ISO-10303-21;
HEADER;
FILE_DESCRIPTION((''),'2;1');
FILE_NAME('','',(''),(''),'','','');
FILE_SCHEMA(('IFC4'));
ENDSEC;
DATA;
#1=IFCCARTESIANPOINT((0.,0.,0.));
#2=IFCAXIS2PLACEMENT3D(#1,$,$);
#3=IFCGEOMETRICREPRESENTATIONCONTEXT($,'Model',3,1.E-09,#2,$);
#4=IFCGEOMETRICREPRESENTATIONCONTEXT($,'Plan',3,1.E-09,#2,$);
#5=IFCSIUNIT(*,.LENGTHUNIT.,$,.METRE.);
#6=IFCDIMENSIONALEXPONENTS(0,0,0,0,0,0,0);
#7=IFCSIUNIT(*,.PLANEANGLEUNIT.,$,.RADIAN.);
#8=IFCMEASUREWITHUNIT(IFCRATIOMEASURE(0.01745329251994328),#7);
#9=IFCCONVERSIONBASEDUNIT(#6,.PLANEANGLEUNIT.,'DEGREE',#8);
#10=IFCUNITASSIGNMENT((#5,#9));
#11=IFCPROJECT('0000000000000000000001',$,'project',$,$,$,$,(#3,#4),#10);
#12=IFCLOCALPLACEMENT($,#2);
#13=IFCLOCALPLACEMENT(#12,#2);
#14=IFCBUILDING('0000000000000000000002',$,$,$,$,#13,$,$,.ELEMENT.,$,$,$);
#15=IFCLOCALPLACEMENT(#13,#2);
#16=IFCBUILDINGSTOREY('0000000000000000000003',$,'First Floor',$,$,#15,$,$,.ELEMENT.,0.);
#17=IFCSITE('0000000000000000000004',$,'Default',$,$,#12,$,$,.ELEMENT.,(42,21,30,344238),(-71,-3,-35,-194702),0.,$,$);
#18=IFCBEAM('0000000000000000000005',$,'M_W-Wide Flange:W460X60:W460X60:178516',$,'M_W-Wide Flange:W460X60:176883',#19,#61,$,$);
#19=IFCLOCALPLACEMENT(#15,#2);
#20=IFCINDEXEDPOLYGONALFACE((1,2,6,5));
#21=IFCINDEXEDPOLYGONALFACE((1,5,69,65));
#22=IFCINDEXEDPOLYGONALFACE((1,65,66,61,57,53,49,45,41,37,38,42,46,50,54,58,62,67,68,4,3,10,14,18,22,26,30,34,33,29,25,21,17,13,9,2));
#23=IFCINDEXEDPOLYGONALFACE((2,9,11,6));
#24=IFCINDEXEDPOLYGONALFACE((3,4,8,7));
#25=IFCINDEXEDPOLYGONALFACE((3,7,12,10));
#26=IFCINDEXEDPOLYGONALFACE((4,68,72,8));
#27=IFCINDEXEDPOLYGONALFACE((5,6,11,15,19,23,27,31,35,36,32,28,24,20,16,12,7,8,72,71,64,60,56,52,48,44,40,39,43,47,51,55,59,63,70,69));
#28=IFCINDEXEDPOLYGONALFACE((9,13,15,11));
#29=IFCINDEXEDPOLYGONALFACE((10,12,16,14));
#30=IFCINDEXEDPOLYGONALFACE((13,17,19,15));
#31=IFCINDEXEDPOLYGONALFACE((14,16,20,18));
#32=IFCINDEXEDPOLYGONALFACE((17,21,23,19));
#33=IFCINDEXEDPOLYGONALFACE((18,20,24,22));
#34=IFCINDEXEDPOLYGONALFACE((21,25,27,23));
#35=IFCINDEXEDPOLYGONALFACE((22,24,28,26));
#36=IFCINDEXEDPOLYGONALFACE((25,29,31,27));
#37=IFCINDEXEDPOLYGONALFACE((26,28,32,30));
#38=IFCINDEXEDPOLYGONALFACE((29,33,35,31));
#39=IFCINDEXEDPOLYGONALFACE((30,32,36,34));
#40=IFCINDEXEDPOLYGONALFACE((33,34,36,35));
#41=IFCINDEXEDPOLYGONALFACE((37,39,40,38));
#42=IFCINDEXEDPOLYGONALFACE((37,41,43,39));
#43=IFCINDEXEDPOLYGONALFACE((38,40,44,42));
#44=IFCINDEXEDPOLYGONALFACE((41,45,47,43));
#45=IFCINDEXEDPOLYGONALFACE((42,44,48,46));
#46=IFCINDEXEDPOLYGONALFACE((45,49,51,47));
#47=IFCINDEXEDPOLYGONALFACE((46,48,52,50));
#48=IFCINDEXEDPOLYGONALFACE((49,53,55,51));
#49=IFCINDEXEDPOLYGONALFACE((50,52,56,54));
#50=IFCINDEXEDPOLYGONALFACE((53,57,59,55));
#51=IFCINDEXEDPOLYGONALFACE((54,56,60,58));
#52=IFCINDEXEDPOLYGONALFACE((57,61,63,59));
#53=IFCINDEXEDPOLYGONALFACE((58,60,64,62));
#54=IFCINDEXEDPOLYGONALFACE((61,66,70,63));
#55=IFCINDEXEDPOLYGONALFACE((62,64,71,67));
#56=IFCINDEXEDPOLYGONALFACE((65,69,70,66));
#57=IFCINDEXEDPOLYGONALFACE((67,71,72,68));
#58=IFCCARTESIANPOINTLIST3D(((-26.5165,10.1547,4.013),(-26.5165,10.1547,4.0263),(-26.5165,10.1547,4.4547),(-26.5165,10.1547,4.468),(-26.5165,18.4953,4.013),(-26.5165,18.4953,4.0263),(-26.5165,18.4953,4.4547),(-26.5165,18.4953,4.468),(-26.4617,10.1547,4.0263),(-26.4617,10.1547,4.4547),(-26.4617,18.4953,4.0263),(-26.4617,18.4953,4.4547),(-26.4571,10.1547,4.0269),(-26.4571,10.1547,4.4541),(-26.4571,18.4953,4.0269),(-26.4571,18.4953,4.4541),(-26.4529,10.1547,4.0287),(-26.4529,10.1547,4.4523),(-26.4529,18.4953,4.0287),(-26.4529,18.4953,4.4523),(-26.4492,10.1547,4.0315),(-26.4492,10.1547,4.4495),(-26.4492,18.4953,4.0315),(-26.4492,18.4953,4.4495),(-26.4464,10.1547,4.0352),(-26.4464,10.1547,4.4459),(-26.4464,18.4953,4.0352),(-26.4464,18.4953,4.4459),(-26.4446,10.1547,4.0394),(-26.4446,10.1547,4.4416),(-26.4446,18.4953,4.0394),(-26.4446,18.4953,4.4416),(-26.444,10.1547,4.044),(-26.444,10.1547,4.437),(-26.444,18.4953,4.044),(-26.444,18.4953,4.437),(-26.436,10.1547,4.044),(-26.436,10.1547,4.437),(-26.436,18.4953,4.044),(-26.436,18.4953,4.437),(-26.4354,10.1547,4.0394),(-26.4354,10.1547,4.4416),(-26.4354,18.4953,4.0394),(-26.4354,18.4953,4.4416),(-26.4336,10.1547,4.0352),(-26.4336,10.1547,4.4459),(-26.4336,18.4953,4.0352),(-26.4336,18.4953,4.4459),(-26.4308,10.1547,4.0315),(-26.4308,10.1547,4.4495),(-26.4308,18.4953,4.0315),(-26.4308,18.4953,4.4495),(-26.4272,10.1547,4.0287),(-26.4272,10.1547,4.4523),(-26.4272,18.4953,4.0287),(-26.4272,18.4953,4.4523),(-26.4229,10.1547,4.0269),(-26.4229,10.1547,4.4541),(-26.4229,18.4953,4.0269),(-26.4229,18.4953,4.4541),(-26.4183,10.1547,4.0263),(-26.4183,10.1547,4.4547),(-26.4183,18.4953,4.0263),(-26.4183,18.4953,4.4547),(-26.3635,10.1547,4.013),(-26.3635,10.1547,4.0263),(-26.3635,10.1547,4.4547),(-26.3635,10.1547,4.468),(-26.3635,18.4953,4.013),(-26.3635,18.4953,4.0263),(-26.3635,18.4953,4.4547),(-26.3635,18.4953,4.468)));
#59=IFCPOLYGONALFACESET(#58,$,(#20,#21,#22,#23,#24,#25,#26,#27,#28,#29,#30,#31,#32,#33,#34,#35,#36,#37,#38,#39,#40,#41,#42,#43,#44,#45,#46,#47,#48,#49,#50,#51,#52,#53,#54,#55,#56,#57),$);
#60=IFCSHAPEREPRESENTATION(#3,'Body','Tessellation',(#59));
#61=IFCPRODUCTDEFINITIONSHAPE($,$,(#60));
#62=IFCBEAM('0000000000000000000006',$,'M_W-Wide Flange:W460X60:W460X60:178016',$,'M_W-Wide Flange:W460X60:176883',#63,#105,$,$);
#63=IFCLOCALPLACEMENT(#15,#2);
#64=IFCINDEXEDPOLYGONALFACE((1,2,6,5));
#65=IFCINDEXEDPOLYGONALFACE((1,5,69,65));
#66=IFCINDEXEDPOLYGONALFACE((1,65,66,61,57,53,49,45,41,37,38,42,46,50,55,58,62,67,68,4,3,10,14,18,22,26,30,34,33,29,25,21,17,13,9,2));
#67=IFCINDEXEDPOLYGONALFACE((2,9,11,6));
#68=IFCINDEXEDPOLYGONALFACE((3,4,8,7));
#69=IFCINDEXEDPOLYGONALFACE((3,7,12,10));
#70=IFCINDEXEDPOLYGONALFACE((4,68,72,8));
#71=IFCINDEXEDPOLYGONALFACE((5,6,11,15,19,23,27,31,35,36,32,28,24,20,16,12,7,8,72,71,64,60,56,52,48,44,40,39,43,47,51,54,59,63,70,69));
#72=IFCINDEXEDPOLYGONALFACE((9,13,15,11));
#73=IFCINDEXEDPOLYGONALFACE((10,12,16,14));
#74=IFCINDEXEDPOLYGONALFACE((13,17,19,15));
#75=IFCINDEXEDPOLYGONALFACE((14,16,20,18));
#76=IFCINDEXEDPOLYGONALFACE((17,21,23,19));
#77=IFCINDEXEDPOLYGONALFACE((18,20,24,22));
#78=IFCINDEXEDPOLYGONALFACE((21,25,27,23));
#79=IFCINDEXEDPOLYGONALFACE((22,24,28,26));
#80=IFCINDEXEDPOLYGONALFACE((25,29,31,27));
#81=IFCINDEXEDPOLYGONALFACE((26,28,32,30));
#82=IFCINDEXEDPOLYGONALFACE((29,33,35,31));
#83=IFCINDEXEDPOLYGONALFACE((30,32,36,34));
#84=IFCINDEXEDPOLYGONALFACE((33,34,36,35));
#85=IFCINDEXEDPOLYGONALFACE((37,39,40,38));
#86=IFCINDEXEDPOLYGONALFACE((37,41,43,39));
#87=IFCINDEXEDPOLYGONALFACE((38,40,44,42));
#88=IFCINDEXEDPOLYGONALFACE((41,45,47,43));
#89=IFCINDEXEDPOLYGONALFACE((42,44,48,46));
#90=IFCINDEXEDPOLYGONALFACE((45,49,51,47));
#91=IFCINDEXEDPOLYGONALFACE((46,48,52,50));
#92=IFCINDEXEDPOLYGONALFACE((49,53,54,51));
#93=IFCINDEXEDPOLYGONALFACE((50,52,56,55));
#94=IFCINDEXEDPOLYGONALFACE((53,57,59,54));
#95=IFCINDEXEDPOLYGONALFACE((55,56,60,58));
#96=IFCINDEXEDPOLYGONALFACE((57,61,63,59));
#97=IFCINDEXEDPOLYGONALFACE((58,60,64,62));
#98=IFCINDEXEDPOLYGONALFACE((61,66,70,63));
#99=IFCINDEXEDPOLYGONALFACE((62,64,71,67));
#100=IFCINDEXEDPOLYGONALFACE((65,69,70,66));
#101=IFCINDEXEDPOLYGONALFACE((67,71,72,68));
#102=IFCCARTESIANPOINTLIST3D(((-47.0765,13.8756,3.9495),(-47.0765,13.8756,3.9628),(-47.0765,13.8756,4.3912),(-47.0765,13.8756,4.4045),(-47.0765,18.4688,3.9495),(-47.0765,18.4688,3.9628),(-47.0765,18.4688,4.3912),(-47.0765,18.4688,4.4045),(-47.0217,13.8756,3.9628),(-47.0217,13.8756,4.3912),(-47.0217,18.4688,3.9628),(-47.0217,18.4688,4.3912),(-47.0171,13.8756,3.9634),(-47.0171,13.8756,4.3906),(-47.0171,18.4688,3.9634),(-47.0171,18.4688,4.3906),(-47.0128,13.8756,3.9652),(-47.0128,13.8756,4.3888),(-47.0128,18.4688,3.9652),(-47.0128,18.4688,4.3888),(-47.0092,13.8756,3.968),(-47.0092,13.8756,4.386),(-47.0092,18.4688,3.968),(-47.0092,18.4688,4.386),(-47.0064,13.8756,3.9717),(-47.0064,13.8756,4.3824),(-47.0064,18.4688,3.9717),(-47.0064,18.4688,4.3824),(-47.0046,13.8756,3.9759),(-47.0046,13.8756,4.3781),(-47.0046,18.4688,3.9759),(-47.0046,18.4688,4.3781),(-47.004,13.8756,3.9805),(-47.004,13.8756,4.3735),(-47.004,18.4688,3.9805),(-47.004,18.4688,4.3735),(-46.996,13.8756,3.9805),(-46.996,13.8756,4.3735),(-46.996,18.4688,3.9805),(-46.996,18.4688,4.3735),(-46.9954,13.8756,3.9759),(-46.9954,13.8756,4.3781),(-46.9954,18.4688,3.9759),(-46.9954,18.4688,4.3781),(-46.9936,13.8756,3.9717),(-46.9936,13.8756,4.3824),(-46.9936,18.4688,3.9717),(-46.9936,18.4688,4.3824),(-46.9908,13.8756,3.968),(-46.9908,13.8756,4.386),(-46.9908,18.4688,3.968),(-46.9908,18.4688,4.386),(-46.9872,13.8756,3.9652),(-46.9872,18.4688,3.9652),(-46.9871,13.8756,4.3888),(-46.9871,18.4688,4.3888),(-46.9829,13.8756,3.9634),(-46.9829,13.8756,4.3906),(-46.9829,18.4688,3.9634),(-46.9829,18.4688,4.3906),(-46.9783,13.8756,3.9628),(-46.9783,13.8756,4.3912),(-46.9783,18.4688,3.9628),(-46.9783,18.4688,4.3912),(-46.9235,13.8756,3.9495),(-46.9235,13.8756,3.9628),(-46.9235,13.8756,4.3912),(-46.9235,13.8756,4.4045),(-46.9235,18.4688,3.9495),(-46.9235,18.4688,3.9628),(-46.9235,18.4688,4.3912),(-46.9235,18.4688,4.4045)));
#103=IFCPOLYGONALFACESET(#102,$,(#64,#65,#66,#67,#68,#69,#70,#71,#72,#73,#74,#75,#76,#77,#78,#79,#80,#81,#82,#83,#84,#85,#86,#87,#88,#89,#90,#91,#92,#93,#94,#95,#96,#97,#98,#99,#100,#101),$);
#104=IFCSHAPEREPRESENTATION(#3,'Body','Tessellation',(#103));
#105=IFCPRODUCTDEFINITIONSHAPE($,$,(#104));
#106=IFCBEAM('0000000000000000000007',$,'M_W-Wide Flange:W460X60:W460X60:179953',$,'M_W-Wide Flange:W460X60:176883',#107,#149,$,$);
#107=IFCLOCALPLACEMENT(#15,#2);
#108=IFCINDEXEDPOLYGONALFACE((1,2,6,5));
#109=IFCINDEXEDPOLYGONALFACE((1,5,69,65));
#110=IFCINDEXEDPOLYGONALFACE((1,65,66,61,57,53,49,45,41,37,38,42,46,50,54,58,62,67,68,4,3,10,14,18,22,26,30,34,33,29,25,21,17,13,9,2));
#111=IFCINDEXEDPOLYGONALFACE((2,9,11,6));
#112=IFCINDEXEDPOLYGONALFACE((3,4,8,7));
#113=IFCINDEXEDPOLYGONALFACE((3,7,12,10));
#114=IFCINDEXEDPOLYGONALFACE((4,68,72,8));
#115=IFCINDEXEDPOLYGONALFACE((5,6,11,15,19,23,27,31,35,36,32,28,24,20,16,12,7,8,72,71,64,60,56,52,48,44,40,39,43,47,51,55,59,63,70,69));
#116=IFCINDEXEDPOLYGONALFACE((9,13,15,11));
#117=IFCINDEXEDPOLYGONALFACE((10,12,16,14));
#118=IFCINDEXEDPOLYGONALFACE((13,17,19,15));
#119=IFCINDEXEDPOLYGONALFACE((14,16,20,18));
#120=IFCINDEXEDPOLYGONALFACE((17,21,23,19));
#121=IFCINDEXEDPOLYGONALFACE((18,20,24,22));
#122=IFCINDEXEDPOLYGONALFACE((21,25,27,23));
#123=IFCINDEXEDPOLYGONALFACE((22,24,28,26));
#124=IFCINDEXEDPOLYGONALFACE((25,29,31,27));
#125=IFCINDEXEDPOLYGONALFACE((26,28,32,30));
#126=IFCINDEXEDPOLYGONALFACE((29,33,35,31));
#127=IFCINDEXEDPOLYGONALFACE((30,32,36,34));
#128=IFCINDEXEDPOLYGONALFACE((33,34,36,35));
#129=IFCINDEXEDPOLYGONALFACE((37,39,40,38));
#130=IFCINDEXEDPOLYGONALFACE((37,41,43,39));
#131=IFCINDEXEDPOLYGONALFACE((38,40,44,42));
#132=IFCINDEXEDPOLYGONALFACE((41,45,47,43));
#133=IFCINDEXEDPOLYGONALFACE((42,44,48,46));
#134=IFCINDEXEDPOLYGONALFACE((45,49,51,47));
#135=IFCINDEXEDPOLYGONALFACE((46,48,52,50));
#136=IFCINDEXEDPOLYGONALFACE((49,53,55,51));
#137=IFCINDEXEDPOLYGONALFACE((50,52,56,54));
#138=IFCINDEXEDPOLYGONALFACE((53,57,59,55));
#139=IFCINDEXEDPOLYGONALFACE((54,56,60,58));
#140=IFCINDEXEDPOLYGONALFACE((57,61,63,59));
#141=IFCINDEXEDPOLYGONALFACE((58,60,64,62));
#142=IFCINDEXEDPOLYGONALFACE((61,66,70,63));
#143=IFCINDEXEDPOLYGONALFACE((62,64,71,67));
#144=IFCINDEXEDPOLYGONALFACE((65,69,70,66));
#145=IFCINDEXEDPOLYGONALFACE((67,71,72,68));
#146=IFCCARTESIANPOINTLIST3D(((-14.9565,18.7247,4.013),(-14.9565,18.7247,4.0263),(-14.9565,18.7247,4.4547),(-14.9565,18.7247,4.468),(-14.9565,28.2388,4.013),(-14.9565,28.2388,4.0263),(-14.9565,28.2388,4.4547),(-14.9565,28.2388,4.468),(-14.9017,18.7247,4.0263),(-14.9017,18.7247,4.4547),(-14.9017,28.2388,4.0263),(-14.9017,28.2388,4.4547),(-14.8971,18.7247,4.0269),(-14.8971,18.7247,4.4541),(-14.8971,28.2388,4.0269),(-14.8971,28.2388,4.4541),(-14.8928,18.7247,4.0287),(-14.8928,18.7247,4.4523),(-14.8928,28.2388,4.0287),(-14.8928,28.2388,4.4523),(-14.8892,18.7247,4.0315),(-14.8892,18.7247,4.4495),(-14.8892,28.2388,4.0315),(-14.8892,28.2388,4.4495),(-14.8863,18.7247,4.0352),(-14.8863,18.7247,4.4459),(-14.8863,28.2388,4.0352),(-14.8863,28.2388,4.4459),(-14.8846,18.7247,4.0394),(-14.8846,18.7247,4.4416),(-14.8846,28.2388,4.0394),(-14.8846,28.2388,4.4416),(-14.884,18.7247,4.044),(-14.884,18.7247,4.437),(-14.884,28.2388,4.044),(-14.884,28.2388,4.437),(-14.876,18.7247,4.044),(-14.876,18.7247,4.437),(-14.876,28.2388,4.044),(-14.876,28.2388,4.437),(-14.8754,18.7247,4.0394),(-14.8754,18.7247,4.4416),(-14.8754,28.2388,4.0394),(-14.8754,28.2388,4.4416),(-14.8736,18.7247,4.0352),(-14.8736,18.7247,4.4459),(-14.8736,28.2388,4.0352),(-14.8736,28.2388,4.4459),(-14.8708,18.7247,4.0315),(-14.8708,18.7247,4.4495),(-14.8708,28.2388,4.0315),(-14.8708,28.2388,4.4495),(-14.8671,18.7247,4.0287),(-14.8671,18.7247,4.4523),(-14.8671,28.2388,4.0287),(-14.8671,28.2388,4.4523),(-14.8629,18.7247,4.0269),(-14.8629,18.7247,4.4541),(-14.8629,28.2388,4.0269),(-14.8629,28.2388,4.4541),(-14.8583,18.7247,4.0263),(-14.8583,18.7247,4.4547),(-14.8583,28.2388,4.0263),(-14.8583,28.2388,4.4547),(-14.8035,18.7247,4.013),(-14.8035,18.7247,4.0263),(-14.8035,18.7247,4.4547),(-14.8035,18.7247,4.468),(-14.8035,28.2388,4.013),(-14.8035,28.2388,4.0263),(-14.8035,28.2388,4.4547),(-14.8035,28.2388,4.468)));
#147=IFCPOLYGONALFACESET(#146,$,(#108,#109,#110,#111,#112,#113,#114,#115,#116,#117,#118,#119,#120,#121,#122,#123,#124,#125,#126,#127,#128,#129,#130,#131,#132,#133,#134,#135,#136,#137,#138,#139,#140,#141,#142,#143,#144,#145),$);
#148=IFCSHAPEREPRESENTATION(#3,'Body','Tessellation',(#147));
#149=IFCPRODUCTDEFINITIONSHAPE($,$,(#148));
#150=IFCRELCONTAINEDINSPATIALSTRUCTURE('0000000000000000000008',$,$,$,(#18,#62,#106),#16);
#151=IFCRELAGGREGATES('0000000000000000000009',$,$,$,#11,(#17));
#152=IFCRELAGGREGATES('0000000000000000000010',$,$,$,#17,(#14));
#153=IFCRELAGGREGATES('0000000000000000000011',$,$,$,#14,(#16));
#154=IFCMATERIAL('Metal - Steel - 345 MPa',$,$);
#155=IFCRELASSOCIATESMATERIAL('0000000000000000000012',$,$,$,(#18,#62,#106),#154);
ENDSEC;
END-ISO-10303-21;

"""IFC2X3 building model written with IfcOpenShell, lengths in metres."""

from ifc_helpers import new_model, entity, si_unit, converted_unit, frame, frame_2d, origin, place, context, project, spatial, polyline, circle_curve, parameter, trimmed, segment, composite_curve, outline, extrude, material, element, save


model = new_model("IFC2X3")

# Units and contexts
model_context = context("Model", 3, precision=1e-09, world=origin())
plan_context = context("Plan", 3, precision=1e-09, world=origin())
ifc_project = project(units=[si_unit("LENGTHUNIT", "METRE"), converted_unit("PLANEANGLEUNIT", "DEGREE", entity("IfcRatioMeasure", 0.01745329251994328), si_unit("PLANEANGLEUNIT", "RADIAN"), dimensions=[0, 0, 0, 0, 0, 0, 0])], contexts=[model_context, plan_context])

# Site, building, storey
site_placement = place(None, origin())
site = spatial("IfcSite", under=ifc_project, at=site_placement, Name="Default", CompositionType="ELEMENT", RefLatitude=(42, 21, 30, 344238), RefLongitude=(-71, -3, -35, -194702), RefElevation=0.0)
building_placement = place(site_placement, origin())
building = spatial("IfcBuilding", under=site, at=building_placement, CompositionType="ELEMENT")
storey_placement = place(building_placement, origin())
storey = spatial("IfcBuildingStorey", under=building, at=storey_placement, Name="First Floor", CompositionType="ELEMENT", Elevation=0.0)

# Beams
ifc_material_1 = material(Name="Metal - Steel - 345 MPa")
beam_1_placement = place(storey_placement, frame((-26.44, 18.6116, 4.468), z_axis=(0.0, 0.0, 1.0), x_axis=(-1.0, 0.0, 0.0)))
element("IfcBeam", 1, at=beam_1_placement, inside=storey, material=ifc_material_1, Name="M_W-Wide Flange:W460X60:W460X60:178516", ObjectType="M_W-Wide Flange:W460X60:176883", context=model_context, shape_type="SweptSolid", body=[
    extrude(outline(composite_curve([segment(polyline([(0.2142, -0.0765), (0.2275, -0.0765)]), True, "CONTINUOUS"), segment(polyline([(0.2275, -0.0765), (0.2275, 0.0765)]), True, "CONTINUOUS"), segment(polyline([(0.2275, 0.0765), (0.2142, 0.0765)]), True, "CONTINUOUS"), segment(polyline([(0.2142, 0.0765), (0.2142, 0.0217)]), True, "CONTINUOUS"), segment(trimmed(circle_curve(frame_2d((0.1965, 0.0217), x_axis=(1.0, 0.0)), 0.0177), [parameter(270.0)], [parameter(360.0)], True, "PARAMETER"), False, "CONTINUOUS"), segment(polyline([(0.1965, 0.004), (-0.1965, 0.004)]), True, "CONTINUOUS"), segment(trimmed(circle_curve(frame_2d((-0.1965, 0.0217), x_axis=(0.0, -1.0)), 0.0177), [parameter(270.0)], [parameter(360.0)], True, "PARAMETER"), False, "CONTINUOUS"), segment(polyline([(-0.2142, 0.0217), (-0.2142, 0.0765)]), True, "CONTINUOUS"), segment(polyline([(-0.2142, 0.0765), (-0.2275, 0.0765)]), True, "CONTINUOUS"), segment(polyline([(-0.2275, 0.0765), (-0.2275, -0.0765)]), True, "CONTINUOUS"), segment(polyline([(-0.2275, -0.0765), (-0.2142, -0.0765)]), True, "CONTINUOUS"), segment(polyline([(-0.2142, -0.0765), (-0.2142, -0.0217)]), True, "CONTINUOUS"), segment(trimmed(circle_curve(frame_2d((-0.1965, -0.0217), x_axis=(-1.0, 0.0)), 0.0177), [parameter(270.0)], [parameter(360.0)], True, "PARAMETER"), False, "CONTINUOUS"), segment(polyline([(-0.1965, -0.004), (0.1965, -0.004)]), True, "CONTINUOUS"), segment(trimmed(circle_curve(frame_2d((0.1965, -0.0217), x_axis=(0.0, 1.0)), 0.0177), [parameter(270.0)], [parameter(0.0)], True, "PARAMETER"), False, "CONTINUOUS"), segment(polyline([(0.2142, -0.0217), (0.2142, -0.0765)]), True, "CONTINUOUS")], self_intersect=False)), frame((0.0, 8.4569, -0.2275), z_axis=(0.0, -1.0, 0.0), x_axis=(0.0, 0.0, -1.0)), (0.0, 0.0, 1.0), 8.3406),
])
beam_2_placement = place(storey_placement, frame((-47.0, 13.7316, 4.4045)))
element("IfcBeam", 2, at=beam_2_placement, inside=storey, material=ifc_material_1, Name="M_W-Wide Flange:W460X60:W460X60:178016", ObjectType="M_W-Wide Flange:W460X60:176883", context=model_context, shape_type="SweptSolid", body=[
    extrude(outline(composite_curve([segment(polyline([(-0.0765, -0.2142), (-0.0765, -0.2275)]), True, "CONTINUOUS"), segment(polyline([(-0.0765, -0.2275), (0.0765, -0.2275)]), True, "CONTINUOUS"), segment(polyline([(0.0765, -0.2275), (0.0765, -0.2142)]), True, "CONTINUOUS"), segment(polyline([(0.0765, -0.2142), (0.0217, -0.2142)]), True, "CONTINUOUS"), segment(trimmed(circle_curve(frame_2d((0.0217, -0.1965), x_axis=(0.0, -1.0)), 0.0177), [parameter(270.0)], [parameter(360.0)], True, "PARAMETER"), False, "CONTINUOUS"), segment(polyline([(0.004, -0.1965), (0.004, 0.1965)]), True, "CONTINUOUS"), segment(trimmed(circle_curve(frame_2d((0.0217, 0.1965), x_axis=(-1.0, 0.0)), 0.0177), [parameter(270.0)], [parameter(360.0)], True, "PARAMETER"), False, "CONTINUOUS"), segment(polyline([(0.0217, 0.2142), (0.0765, 0.2142)]), True, "CONTINUOUS"), segment(polyline([(0.0765, 0.2142), (0.0765, 0.2275)]), True, "CONTINUOUS"), segment(polyline([(0.0765, 0.2275), (-0.0765, 0.2275)]), True, "CONTINUOUS"), segment(polyline([(-0.0765, 0.2275), (-0.0765, 0.2142)]), True, "CONTINUOUS"), segment(polyline([(-0.0765, 0.2142), (-0.0217, 0.2142)]), True, "CONTINUOUS"), segment(trimmed(circle_curve(frame_2d((-0.0217, 0.1965), x_axis=(0.0, 1.0)), 0.0177), [parameter(270.0)], [parameter(360.0)], True, "PARAMETER"), False, "CONTINUOUS"), segment(polyline([(-0.004, 0.1965), (-0.004, -0.1965)]), True, "CONTINUOUS"), segment(trimmed(circle_curve(frame_2d((-0.0217, -0.1965), x_axis=(1.0, 0.0)), 0.0177), [parameter(270.0)], [parameter(0.0)], True, "PARAMETER"), False, "CONTINUOUS"), segment(polyline([(-0.0217, -0.2142), (-0.0765, -0.2142)]), True, "CONTINUOUS")], self_intersect=False)), frame((0.0, 0.144, -0.2275), z_axis=(0.0, -1.0, 0.0), x_axis=(1.0, 0.0, 0.0)), (0.0, 0.0, -1.0), 4.5932),
])
beam_3_placement = place(storey_placement, frame((-14.88, 18.6086, 4.468)))
element("IfcBeam", 3, at=beam_3_placement, inside=storey, material=ifc_material_1, Name="M_W-Wide Flange:W460X60:W460X60:179953", ObjectType="M_W-Wide Flange:W460X60:176883", context=model_context, shape_type="SweptSolid", body=[
    extrude(outline(composite_curve([segment(polyline([(-0.0765, -0.2142), (-0.0765, -0.2275)]), True, "CONTINUOUS"), segment(polyline([(-0.0765, -0.2275), (0.0765, -0.2275)]), True, "CONTINUOUS"), segment(polyline([(0.0765, -0.2275), (0.0765, -0.2142)]), True, "CONTINUOUS"), segment(polyline([(0.0765, -0.2142), (0.0217, -0.2142)]), True, "CONTINUOUS"), segment(trimmed(circle_curve(frame_2d((0.0217, -0.1965), x_axis=(0.0, -1.0)), 0.0177), [parameter(270.0)], [parameter(360.0)], True, "PARAMETER"), False, "CONTINUOUS"), segment(polyline([(0.004, -0.1965), (0.004, 0.1965)]), True, "CONTINUOUS"), segment(trimmed(circle_curve(frame_2d((0.0217, 0.1965), x_axis=(-1.0, 0.0)), 0.0177), [parameter(270.0)], [parameter(360.0)], True, "PARAMETER"), False, "CONTINUOUS"), segment(polyline([(0.0217, 0.2142), (0.0765, 0.2142)]), True, "CONTINUOUS"), segment(polyline([(0.0765, 0.2142), (0.0765, 0.2275)]), True, "CONTINUOUS"), segment(polyline([(0.0765, 0.2275), (-0.0765, 0.2275)]), True, "CONTINUOUS"), segment(polyline([(-0.0765, 0.2275), (-0.0765, 0.2142)]), True, "CONTINUOUS"), segment(polyline([(-0.0765, 0.2142), (-0.0217, 0.2142)]), True, "CONTINUOUS"), segment(trimmed(circle_curve(frame_2d((-0.0217, 0.1965), x_axis=(0.0, 1.0)), 0.0177), [parameter(270.0)], [parameter(360.0)], True, "PARAMETER"), False, "CONTINUOUS"), segment(polyline([(-0.004, 0.1965), (-0.004, -0.1965)]), True, "CONTINUOUS"), segment(trimmed(circle_curve(frame_2d((-0.0217, -0.1965), x_axis=(1.0, 0.0)), 0.0177), [parameter(270.0)], [parameter(0.0)], True, "PARAMETER"), False, "CONTINUOUS"), segment(polyline([(-0.0217, -0.2142), (-0.0765, -0.2142)]), True, "CONTINUOUS")], self_intersect=False)), frame((0.0, 0.1161, -0.2275), z_axis=(0.0, -1.0, 0.0), x_axis=(1.0, 0.0, 0.0)), (0.0, 0.0, -1.0), 9.5141),
])

save(model, "model.ifc")
